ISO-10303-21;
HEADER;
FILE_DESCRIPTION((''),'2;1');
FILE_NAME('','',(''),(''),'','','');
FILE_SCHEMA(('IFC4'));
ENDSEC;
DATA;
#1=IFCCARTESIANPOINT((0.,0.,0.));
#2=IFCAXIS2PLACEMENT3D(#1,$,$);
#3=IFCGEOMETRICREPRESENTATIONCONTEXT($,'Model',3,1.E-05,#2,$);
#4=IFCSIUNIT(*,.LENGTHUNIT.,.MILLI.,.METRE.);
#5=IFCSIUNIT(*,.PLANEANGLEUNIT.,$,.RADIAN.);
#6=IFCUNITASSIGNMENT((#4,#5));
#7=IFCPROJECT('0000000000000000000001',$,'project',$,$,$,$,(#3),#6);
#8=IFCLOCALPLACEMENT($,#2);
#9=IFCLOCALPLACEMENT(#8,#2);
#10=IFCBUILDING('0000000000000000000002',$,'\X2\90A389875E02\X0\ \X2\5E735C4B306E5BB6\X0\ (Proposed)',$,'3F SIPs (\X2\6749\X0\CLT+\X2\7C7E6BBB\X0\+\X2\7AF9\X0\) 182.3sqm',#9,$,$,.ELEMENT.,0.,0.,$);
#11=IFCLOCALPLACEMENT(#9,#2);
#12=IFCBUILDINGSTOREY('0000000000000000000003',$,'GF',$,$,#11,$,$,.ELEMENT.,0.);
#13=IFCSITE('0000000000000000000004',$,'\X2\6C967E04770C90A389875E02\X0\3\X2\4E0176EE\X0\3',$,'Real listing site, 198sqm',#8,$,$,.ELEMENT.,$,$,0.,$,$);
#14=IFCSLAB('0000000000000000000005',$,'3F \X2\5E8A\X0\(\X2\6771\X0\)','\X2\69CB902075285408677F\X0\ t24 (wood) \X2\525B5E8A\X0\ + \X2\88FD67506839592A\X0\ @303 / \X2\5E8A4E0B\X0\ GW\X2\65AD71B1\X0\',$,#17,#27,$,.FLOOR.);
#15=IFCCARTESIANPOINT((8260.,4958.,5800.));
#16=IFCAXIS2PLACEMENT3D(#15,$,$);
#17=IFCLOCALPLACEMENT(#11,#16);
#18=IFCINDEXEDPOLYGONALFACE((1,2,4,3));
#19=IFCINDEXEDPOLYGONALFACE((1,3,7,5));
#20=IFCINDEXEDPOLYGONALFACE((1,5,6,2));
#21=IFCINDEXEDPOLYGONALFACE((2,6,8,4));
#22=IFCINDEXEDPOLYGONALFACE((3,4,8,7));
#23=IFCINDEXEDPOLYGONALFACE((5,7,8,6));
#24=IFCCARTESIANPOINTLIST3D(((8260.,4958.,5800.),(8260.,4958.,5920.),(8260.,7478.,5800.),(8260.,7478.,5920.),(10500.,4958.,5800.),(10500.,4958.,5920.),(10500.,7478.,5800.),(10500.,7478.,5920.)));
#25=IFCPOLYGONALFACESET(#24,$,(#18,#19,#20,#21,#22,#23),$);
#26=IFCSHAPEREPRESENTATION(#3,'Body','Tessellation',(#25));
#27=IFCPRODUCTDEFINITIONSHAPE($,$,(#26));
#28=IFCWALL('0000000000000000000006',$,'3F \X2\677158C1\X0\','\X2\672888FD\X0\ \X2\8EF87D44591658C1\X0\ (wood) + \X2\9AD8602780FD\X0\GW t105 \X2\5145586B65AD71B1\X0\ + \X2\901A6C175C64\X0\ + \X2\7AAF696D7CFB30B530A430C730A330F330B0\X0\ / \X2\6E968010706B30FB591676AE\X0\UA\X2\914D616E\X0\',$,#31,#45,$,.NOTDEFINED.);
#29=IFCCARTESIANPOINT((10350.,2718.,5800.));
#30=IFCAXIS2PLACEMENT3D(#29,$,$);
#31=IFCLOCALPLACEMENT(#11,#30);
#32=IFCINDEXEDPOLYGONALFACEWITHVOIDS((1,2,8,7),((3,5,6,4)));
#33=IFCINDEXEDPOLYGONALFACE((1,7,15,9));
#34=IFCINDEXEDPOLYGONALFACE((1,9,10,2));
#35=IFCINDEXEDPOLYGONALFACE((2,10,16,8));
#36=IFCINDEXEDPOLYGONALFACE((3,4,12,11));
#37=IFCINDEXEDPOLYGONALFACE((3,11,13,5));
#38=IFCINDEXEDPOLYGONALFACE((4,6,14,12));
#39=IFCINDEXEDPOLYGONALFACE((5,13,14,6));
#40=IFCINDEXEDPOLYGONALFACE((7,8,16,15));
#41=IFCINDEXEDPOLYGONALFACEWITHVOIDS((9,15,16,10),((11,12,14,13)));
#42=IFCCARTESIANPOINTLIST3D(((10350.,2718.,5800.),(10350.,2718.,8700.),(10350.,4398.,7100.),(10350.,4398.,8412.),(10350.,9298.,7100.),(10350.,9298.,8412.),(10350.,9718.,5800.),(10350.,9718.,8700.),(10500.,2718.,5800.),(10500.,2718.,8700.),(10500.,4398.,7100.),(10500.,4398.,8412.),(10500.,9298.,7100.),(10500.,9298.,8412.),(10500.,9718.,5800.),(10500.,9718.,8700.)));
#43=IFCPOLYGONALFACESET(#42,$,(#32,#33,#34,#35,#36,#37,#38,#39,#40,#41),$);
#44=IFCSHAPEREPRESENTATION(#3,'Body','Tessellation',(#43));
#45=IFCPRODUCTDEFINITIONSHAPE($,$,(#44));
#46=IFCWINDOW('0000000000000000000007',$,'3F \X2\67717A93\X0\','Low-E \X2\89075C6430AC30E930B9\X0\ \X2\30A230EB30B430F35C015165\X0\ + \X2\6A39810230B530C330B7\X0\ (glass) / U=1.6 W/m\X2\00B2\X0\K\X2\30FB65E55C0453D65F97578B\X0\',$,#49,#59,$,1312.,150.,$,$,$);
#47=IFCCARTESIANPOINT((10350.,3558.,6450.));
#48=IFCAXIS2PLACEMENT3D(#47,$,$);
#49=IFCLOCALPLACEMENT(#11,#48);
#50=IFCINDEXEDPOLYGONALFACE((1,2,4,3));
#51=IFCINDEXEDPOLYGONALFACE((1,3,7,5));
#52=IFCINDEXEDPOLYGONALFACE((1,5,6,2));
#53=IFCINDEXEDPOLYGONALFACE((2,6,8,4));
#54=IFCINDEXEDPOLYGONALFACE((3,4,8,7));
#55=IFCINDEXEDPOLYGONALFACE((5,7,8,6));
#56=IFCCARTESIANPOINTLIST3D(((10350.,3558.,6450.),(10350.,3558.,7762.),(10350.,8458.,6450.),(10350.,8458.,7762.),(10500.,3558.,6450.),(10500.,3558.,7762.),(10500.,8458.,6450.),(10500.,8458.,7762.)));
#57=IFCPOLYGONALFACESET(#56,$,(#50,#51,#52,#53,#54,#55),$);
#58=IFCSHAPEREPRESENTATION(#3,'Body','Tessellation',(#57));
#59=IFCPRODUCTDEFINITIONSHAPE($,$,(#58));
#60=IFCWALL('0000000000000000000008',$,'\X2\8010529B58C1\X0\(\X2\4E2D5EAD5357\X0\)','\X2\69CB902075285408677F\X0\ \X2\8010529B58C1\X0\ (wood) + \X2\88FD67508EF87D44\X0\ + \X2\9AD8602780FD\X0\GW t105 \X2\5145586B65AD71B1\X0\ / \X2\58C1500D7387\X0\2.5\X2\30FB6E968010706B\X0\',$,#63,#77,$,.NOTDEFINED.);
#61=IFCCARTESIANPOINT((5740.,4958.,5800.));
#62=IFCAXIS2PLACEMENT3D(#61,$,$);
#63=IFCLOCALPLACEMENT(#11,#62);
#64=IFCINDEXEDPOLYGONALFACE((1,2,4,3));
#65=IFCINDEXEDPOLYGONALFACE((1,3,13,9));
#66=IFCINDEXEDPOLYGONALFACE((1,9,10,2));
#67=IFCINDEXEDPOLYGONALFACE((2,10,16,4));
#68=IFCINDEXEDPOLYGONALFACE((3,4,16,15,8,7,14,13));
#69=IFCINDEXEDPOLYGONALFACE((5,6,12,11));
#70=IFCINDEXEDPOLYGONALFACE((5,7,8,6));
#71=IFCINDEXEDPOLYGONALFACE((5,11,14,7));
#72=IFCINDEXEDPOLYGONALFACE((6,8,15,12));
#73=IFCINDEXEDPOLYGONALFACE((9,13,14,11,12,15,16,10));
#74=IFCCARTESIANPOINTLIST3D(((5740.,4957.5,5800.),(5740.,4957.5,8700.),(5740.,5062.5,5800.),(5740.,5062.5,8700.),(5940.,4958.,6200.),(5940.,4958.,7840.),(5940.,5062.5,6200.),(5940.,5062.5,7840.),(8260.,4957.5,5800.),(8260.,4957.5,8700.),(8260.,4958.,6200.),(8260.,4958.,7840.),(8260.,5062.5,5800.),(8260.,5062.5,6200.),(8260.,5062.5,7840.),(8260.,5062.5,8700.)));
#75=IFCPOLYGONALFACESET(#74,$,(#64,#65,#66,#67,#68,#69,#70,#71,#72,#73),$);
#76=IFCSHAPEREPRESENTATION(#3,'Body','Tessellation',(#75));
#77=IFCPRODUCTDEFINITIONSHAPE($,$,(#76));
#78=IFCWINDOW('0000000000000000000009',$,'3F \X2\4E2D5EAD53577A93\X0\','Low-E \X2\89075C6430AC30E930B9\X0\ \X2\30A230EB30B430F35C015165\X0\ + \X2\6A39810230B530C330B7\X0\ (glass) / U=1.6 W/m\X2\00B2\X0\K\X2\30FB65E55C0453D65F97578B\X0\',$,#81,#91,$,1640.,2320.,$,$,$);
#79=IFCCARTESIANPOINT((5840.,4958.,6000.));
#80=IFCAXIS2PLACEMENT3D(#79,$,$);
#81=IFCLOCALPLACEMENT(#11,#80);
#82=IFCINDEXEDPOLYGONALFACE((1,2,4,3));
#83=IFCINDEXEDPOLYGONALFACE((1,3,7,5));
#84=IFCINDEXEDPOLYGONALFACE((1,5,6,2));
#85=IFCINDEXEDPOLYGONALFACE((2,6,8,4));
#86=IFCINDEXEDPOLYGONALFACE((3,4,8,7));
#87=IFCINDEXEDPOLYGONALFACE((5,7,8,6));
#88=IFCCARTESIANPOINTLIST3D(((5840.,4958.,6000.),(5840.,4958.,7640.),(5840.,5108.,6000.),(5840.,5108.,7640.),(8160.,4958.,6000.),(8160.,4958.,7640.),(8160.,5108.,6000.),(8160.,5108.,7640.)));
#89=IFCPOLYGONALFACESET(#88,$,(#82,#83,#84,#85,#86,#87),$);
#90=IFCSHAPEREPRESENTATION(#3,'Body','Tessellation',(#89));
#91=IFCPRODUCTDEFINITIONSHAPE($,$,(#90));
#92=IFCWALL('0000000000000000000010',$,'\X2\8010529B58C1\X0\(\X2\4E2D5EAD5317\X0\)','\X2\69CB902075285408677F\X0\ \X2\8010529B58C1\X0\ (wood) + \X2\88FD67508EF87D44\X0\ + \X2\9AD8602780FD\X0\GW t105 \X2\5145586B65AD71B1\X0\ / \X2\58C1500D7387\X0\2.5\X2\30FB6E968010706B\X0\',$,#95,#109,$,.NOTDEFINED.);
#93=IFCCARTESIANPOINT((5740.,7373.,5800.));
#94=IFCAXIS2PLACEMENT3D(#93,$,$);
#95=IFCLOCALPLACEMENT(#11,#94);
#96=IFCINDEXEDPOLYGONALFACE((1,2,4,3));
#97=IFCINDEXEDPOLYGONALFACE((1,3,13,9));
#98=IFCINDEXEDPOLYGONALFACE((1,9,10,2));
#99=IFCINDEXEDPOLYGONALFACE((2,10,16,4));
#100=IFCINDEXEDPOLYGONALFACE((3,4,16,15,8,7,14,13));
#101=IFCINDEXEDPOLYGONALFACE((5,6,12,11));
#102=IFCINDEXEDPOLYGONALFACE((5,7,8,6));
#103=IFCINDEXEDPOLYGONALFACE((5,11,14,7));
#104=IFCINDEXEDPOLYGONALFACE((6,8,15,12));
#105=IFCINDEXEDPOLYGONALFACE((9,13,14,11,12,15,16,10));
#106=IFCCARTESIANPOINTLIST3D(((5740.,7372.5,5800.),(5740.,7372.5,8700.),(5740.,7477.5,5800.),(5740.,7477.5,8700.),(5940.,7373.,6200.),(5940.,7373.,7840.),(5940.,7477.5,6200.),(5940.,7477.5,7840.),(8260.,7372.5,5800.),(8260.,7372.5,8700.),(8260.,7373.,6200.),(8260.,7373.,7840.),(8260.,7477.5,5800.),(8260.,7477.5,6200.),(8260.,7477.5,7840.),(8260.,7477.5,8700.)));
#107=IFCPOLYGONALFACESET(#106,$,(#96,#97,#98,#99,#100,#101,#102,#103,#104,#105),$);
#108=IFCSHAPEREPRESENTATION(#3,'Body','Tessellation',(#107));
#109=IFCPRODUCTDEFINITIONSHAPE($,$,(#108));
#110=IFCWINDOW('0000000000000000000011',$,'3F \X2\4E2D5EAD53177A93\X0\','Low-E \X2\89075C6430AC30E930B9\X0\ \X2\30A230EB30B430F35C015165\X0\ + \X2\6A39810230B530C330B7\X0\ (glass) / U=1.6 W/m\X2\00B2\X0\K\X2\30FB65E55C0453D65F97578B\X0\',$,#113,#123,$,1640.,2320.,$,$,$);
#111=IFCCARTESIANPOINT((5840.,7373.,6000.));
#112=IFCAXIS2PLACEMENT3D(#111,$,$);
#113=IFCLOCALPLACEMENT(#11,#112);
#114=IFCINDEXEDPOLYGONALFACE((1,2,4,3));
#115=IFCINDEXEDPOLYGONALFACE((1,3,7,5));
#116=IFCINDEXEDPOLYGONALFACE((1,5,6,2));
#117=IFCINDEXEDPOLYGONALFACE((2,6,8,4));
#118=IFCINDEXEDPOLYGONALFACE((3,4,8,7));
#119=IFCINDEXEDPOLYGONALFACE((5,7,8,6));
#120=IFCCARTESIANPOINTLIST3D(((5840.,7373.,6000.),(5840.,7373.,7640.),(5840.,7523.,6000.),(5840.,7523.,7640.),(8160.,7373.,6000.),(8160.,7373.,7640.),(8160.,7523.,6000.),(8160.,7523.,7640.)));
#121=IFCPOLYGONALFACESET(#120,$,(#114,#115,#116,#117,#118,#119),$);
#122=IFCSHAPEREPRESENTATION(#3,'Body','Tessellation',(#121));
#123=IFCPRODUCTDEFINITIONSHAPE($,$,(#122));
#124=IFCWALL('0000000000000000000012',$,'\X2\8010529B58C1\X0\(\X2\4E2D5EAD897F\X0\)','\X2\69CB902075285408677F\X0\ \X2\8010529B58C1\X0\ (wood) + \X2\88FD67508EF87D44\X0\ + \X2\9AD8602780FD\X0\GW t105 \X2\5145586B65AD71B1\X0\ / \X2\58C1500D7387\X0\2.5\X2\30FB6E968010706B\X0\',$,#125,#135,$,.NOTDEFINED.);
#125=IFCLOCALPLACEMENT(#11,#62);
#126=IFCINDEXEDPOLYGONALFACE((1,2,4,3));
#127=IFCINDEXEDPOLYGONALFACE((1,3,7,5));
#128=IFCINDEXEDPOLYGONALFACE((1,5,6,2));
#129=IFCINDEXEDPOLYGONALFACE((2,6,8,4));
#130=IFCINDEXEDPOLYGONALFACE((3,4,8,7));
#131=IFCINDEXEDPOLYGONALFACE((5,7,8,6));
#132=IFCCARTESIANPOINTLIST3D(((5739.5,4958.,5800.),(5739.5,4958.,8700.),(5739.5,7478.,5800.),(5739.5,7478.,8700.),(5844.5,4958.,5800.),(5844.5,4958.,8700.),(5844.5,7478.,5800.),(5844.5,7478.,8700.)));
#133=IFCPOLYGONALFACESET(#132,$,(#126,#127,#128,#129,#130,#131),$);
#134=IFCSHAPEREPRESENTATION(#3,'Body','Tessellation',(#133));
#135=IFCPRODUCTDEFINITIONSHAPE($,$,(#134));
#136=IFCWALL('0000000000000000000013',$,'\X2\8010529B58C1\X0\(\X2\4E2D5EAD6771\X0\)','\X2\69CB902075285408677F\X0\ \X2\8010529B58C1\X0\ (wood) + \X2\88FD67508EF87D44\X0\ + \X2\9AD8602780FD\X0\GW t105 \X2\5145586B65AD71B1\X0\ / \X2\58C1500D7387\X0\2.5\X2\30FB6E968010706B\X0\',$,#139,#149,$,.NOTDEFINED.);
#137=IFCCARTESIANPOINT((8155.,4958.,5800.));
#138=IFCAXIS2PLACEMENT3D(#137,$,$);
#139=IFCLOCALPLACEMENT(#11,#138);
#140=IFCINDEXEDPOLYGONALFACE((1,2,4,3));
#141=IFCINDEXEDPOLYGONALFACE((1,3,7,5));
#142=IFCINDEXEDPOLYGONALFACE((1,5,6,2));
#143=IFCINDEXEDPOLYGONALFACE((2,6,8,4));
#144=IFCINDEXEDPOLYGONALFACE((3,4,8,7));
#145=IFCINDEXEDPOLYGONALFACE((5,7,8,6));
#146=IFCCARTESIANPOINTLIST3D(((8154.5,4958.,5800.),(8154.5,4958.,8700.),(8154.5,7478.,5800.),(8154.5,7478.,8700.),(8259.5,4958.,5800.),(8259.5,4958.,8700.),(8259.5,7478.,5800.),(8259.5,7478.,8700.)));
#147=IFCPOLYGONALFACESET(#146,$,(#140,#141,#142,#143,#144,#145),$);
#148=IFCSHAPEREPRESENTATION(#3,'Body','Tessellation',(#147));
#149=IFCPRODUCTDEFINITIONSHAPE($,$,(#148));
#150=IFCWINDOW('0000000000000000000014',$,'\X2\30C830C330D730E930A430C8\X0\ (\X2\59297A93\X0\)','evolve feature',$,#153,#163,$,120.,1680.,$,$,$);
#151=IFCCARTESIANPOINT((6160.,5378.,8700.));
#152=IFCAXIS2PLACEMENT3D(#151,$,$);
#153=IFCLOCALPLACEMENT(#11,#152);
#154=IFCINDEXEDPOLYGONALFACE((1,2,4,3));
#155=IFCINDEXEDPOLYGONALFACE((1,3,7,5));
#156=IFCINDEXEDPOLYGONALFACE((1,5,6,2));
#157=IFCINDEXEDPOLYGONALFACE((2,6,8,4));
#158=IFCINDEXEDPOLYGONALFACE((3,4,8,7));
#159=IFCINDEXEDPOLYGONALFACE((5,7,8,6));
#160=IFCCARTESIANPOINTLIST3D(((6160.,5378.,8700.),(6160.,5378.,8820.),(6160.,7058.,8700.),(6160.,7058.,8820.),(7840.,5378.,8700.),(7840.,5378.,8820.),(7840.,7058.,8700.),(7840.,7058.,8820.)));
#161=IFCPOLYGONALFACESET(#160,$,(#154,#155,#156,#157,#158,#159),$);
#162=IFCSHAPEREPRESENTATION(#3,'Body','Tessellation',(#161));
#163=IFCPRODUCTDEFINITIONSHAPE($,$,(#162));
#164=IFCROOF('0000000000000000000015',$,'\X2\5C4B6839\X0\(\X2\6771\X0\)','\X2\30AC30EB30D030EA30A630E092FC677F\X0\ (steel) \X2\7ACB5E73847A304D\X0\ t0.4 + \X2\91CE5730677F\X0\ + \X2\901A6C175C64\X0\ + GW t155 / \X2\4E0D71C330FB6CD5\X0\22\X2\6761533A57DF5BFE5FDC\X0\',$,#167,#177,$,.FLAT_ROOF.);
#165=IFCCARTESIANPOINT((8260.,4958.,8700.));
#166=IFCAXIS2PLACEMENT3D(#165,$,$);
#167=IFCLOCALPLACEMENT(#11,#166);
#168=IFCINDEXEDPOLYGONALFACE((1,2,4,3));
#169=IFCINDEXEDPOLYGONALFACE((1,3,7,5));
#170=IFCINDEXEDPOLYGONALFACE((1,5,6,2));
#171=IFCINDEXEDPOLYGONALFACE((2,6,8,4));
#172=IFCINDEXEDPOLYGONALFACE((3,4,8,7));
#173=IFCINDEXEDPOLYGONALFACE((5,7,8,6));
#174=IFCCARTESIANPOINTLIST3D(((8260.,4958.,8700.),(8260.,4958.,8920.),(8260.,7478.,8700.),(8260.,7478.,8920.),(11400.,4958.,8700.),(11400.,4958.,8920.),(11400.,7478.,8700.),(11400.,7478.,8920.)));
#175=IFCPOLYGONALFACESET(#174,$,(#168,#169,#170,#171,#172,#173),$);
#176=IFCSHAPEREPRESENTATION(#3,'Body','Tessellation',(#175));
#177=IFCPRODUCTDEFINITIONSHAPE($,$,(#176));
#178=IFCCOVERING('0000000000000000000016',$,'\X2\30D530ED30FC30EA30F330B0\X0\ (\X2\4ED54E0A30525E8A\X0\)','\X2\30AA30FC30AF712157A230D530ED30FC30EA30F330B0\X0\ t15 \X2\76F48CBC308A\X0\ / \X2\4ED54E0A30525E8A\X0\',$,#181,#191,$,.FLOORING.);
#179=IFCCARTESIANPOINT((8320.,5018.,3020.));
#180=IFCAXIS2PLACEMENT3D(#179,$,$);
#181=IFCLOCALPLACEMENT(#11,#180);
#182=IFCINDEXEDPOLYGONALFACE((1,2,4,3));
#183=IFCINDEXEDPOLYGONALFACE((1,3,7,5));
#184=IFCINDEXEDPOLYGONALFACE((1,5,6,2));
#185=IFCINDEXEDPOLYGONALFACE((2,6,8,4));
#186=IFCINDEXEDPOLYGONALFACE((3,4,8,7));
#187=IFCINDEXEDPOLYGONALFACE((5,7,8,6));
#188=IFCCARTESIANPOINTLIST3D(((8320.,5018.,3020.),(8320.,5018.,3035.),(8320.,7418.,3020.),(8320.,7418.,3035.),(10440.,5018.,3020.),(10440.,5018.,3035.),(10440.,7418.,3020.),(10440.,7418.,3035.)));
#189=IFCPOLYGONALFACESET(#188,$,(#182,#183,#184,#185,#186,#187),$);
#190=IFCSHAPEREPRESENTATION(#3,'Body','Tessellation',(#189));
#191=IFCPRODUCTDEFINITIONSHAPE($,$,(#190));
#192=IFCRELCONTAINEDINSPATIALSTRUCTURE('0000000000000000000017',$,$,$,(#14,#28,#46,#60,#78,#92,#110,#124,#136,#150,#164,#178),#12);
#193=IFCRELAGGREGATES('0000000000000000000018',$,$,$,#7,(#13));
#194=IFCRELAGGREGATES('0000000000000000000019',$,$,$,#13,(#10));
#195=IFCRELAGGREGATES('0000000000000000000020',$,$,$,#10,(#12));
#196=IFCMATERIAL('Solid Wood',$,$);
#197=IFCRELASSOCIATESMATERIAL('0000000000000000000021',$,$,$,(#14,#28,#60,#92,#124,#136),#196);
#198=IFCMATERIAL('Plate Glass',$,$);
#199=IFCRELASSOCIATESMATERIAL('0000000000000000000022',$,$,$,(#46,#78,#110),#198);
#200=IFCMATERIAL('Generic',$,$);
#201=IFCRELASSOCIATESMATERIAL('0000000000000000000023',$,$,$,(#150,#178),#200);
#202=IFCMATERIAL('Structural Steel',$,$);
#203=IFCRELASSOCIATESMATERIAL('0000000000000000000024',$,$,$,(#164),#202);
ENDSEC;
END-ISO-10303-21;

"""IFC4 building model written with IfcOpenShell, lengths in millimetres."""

from ifc_helpers import new_model, si_unit, frame, frame_2d, origin, place, context, project, spatial, rectangle, extrude, material, element, fill, save


model = new_model("IFC4")

# Units and contexts
model_context = context("Model", 3, precision=1e-05, world=origin())
ifc_project = project(units=[si_unit("LENGTHUNIT", "METRE", prefix="MILLI"), si_unit("PLANEANGLEUNIT", "RADIAN")], contexts=[model_context])

# Site, building, storey
site_placement = place(None, origin())
site = spatial("IfcSite", under=ifc_project, at=site_placement, Name="沖縄県那覇市3丁目3", ObjectType="Real listing site, 198sqm", CompositionType="ELEMENT", RefElevation=0.0)
building_placement = place(site_placement, origin())
building = spatial("IfcBuilding", under=site, at=building_placement, Name="那覇市 平屋の家 (Proposed)", ObjectType="3F SIPs (杉CLT+籾殻+竹) 182.3sqm", CompositionType="ELEMENT", ElevationOfRefHeight=0.0, ElevationOfTerrain=0.0)
storey_placement = place(building_placement, origin())
storey = spatial("IfcBuildingStorey", under=building, at=storey_placement, Name="GF", CompositionType="ELEMENT", Elevation=0.0)

# Slab
ifc_material_1 = material(Name="Solid Wood")
slab_placement = place(storey_placement, frame((8260.0, 4958.0, 5800.0)))
element("IfcSlab", 1, at=slab_placement, inside=storey, material=ifc_material_1, Name="3F 床(東)", Description="構造用合板 t24 (wood) 剛床 + 製材根太 @303 / 床下 GW断熱", PredefinedType="FLOOR", context=model_context, shape_type="SweptSolid", body=[
    extrude(rectangle(XDim=2240.0, YDim=2520.0, at=frame_2d((1120.0, 1260.0))), frame((8260.0, 4958.0, 5800.0)), (0.0, 0.0, 1.0), 120.0),
])

# Walls, openings, windows
wall_1_placement = place(storey_placement, frame((10350.0, 2718.0, 5800.0)))
wall_1 = element("IfcWall", 2, at=wall_1_placement, inside=storey, material=ifc_material_1, Name="3F 東壁", Description="木製 軸組外壁 (wood) + 高性能GW t105 充填断熱 + 通気層 + 窯業系サイディング / 準耐火・外皮UA配慮", PredefinedType="NOTDEFINED", context=model_context, shape_type="SweptSolid", body=[
    extrude(rectangle(XDim=150.0, YDim=7000.0, at=frame_2d((75.0, 3500.0))), frame((10350.0, 2718.0, 5800.0)), (0.0, 0.0, 1.0), 2900.0),
])
opening_1_placement = place(storey_placement, frame((10350.0, 3558.0, 6450.0)))
opening_1 = element("IfcOpeningElement", 3, at=opening_1_placement, cuts=wall_1, PredefinedType="NOTDEFINED", context=model_context, shape_type="SweptSolid", body=[
    extrude(rectangle(XDim=150.0, YDim=4900.0, at=frame_2d((75.0, 2450.0))), frame((10350.0, 3558.0, 6450.0)), (0.0, 0.0, 1.0), 1312.0),
])
ifc_material_2 = material(Name="Plate Glass")
window_1_placement = place(storey_placement, frame((10350.0, 3558.0, 6450.0)))
window_1 = element("IfcWindow", 4, at=window_1_placement, inside=storey, material=ifc_material_2, Name="3F 東窓", Description="Low-E 複層ガラス アルゴン封入 + 樹脂サッシ (glass) / U=1.6 W/m²K・日射取得型", OverallHeight=1312.0, OverallWidth=150.0, context=model_context, shape_type="SweptSolid", body=[
    extrude(rectangle(XDim=150.0, YDim=4900.0, at=frame_2d((75.0, 2450.0))), frame((10350.0, 3558.0, 6450.0)), (0.0, 0.0, 1.0), 1312.0),
])
fill(opening_1, window_1)
wall_2_placement = place(storey_placement, frame((5740.0, 4958.0, 5800.0)))
wall_2 = element("IfcWall", 5, at=wall_2_placement, inside=storey, material=ifc_material_1, Name="耐力壁(中庭南)", Description="構造用合板 耐力壁 (wood) + 製材軸組 + 高性能GW t105 充填断熱 / 壁倍率2.5・準耐火", PredefinedType="NOTDEFINED", context=model_context, shape_type="SweptSolid", body=[
    extrude(rectangle(XDim=2520.0, YDim=105.0, at=frame_2d((1260.0, 52.0))), frame((5740.0, 4958.0, 5800.0)), (0.0, 0.0, 1.0), 2900.0),
])
opening_2_placement = place(storey_placement, frame((5840.0, 4958.0, 6000.0)))
opening_2 = element("IfcOpeningElement", 6, at=opening_2_placement, cuts=wall_2, PredefinedType="NOTDEFINED", context=model_context, shape_type="SweptSolid", body=[
    extrude(rectangle(XDim=2320.0, YDim=150.0, at=frame_2d((1160.0, 75.0))), frame((5840.0, 4958.0, 6000.0)), (0.0, 0.0, 1.0), 1640.0),
])
window_2_placement = place(storey_placement, frame((5840.0, 4958.0, 6000.0)))
window_2 = element("IfcWindow", 7, at=window_2_placement, inside=storey, material=ifc_material_2, Name="3F 中庭南窓", Description="Low-E 複層ガラス アルゴン封入 + 樹脂サッシ (glass) / U=1.6 W/m²K・日射取得型", OverallHeight=1640.0, OverallWidth=2320.0, context=model_context, shape_type="SweptSolid", body=[
    extrude(rectangle(XDim=2320.0, YDim=150.0, at=frame_2d((1160.0, 75.0))), frame((5840.0, 4958.0, 6000.0)), (0.0, 0.0, 1.0), 1640.0),
])
fill(opening_2, window_2)
wall_3_placement = place(storey_placement, frame((5740.0, 7373.0, 5800.0)))
wall_3 = element("IfcWall", 8, at=wall_3_placement, inside=storey, material=ifc_material_1, Name="耐力壁(中庭北)", Description="構造用合板 耐力壁 (wood) + 製材軸組 + 高性能GW t105 充填断熱 / 壁倍率2.5・準耐火", PredefinedType="NOTDEFINED", context=model_context, shape_type="SweptSolid", body=[
    extrude(rectangle(XDim=2520.0, YDim=105.0, at=frame_2d((1260.0, 52.0))), frame((5740.0, 7373.0, 5800.0)), (0.0, 0.0, 1.0), 2900.0),
])
opening_3_placement = place(storey_placement, frame((5840.0, 7373.0, 6000.0)))
opening_3 = element("IfcOpeningElement", 9, at=opening_3_placement, cuts=wall_3, PredefinedType="NOTDEFINED", context=model_context, shape_type="SweptSolid", body=[
    extrude(rectangle(XDim=2320.0, YDim=150.0, at=frame_2d((1160.0, 75.0))), frame((5840.0, 7373.0, 6000.0)), (0.0, 0.0, 1.0), 1640.0),
])
window_3_placement = place(storey_placement, frame((5840.0, 7373.0, 6000.0)))
window_3 = element("IfcWindow", 10, at=window_3_placement, inside=storey, material=ifc_material_2, Name="3F 中庭北窓", Description="Low-E 複層ガラス アルゴン封入 + 樹脂サッシ (glass) / U=1.6 W/m²K・日射取得型", OverallHeight=1640.0, OverallWidth=2320.0, context=model_context, shape_type="SweptSolid", body=[
    extrude(rectangle(XDim=2320.0, YDim=150.0, at=frame_2d((1160.0, 75.0))), frame((5840.0, 7373.0, 6000.0)), (0.0, 0.0, 1.0), 1640.0),
])
fill(opening_3, window_3)

# Walls
wall_4_placement = place(storey_placement, frame((5740.0, 4958.0, 5800.0)))
element("IfcWall", 11, at=wall_4_placement, inside=storey, material=ifc_material_1, Name="耐力壁(中庭西)", Description="構造用合板 耐力壁 (wood) + 製材軸組 + 高性能GW t105 充填断熱 / 壁倍率2.5・準耐火", PredefinedType="NOTDEFINED", context=model_context, shape_type="SweptSolid", body=[
    extrude(rectangle(XDim=105.0, YDim=2520.0, at=frame_2d((52.0, 1260.0))), frame((5740.0, 4958.0, 5800.0)), (0.0, 0.0, 1.0), 2900.0),
])
wall_5_placement = place(storey_placement, frame((8155.0, 4958.0, 5800.0)))
element("IfcWall", 12, at=wall_5_placement, inside=storey, material=ifc_material_1, Name="耐力壁(中庭東)", Description="構造用合板 耐力壁 (wood) + 製材軸組 + 高性能GW t105 充填断熱 / 壁倍率2.5・準耐火", PredefinedType="NOTDEFINED", context=model_context, shape_type="SweptSolid", body=[
    extrude(rectangle(XDim=105.0, YDim=2520.0, at=frame_2d((52.0, 1260.0))), frame((8155.0, 4958.0, 5800.0)), (0.0, 0.0, 1.0), 2900.0),
])

# Window
ifc_material_3 = material(Name="Generic")
window_4_placement = place(storey_placement, frame((6160.0, 5378.0, 8700.0)))
element("IfcWindow", 13, at=window_4_placement, inside=storey, material=ifc_material_3, Name="トップライト (天窓)", Description="evolve feature", OverallHeight=120.0, OverallWidth=1680.0, context=model_context, shape_type="SweptSolid", body=[
    extrude(rectangle(XDim=1680.0, YDim=1680.0, at=frame_2d((840.0, 840.0))), frame((6160.0, 5378.0, 8700.0)), (0.0, 0.0, 1.0), 120.0),
])

# Roof
ifc_material_4 = material(Name="Structural Steel")
for number, where, name in (
    (14, (8260.0, 4958.0, 8700.0), "屋根(東)"),
):
    element("IfcRoof", number, at=place(storey_placement, frame(where)), inside=storey, material=ifc_material_4, Name=name, Description="ガルバリウム鋼板 (steel) 立平葺き t0.4 + 野地板 + 通気層 + GW t155 / 不燃・法22条区域対応", PredefinedType="FLAT_ROOF", context=model_context, shape_type="SweptSolid", body=[
        extrude(rectangle(XDim=3140.0, YDim=2520.0, at=frame_2d((1570.0, 1260.0))), frame((8260.0, 4958.0, 8700.0)), (0.0, 0.0, 1.0), 220.0),
    ])

# Covering
covering_1_placement = place(storey_placement, frame((8320.0, 5018.0, 3020.0)))
element("IfcCovering", 15, at=covering_1_placement, inside=storey, material=ifc_material_3, Name="フローリング (仕上げ床)", Description="オーク無垢フローリング t15 直貼り / 仕上げ床", PredefinedType="FLOORING", context=model_context, shape_type="SweptSolid", body=[
    extrude(rectangle(XDim=2120.0, YDim=2400.0, at=frame_2d((1060.0, 1200.0))), frame((8320.0, 5018.0, 3020.0)), (0.0, 0.0, 1.0), 15.0),
])

save(model, "model.ifc")
